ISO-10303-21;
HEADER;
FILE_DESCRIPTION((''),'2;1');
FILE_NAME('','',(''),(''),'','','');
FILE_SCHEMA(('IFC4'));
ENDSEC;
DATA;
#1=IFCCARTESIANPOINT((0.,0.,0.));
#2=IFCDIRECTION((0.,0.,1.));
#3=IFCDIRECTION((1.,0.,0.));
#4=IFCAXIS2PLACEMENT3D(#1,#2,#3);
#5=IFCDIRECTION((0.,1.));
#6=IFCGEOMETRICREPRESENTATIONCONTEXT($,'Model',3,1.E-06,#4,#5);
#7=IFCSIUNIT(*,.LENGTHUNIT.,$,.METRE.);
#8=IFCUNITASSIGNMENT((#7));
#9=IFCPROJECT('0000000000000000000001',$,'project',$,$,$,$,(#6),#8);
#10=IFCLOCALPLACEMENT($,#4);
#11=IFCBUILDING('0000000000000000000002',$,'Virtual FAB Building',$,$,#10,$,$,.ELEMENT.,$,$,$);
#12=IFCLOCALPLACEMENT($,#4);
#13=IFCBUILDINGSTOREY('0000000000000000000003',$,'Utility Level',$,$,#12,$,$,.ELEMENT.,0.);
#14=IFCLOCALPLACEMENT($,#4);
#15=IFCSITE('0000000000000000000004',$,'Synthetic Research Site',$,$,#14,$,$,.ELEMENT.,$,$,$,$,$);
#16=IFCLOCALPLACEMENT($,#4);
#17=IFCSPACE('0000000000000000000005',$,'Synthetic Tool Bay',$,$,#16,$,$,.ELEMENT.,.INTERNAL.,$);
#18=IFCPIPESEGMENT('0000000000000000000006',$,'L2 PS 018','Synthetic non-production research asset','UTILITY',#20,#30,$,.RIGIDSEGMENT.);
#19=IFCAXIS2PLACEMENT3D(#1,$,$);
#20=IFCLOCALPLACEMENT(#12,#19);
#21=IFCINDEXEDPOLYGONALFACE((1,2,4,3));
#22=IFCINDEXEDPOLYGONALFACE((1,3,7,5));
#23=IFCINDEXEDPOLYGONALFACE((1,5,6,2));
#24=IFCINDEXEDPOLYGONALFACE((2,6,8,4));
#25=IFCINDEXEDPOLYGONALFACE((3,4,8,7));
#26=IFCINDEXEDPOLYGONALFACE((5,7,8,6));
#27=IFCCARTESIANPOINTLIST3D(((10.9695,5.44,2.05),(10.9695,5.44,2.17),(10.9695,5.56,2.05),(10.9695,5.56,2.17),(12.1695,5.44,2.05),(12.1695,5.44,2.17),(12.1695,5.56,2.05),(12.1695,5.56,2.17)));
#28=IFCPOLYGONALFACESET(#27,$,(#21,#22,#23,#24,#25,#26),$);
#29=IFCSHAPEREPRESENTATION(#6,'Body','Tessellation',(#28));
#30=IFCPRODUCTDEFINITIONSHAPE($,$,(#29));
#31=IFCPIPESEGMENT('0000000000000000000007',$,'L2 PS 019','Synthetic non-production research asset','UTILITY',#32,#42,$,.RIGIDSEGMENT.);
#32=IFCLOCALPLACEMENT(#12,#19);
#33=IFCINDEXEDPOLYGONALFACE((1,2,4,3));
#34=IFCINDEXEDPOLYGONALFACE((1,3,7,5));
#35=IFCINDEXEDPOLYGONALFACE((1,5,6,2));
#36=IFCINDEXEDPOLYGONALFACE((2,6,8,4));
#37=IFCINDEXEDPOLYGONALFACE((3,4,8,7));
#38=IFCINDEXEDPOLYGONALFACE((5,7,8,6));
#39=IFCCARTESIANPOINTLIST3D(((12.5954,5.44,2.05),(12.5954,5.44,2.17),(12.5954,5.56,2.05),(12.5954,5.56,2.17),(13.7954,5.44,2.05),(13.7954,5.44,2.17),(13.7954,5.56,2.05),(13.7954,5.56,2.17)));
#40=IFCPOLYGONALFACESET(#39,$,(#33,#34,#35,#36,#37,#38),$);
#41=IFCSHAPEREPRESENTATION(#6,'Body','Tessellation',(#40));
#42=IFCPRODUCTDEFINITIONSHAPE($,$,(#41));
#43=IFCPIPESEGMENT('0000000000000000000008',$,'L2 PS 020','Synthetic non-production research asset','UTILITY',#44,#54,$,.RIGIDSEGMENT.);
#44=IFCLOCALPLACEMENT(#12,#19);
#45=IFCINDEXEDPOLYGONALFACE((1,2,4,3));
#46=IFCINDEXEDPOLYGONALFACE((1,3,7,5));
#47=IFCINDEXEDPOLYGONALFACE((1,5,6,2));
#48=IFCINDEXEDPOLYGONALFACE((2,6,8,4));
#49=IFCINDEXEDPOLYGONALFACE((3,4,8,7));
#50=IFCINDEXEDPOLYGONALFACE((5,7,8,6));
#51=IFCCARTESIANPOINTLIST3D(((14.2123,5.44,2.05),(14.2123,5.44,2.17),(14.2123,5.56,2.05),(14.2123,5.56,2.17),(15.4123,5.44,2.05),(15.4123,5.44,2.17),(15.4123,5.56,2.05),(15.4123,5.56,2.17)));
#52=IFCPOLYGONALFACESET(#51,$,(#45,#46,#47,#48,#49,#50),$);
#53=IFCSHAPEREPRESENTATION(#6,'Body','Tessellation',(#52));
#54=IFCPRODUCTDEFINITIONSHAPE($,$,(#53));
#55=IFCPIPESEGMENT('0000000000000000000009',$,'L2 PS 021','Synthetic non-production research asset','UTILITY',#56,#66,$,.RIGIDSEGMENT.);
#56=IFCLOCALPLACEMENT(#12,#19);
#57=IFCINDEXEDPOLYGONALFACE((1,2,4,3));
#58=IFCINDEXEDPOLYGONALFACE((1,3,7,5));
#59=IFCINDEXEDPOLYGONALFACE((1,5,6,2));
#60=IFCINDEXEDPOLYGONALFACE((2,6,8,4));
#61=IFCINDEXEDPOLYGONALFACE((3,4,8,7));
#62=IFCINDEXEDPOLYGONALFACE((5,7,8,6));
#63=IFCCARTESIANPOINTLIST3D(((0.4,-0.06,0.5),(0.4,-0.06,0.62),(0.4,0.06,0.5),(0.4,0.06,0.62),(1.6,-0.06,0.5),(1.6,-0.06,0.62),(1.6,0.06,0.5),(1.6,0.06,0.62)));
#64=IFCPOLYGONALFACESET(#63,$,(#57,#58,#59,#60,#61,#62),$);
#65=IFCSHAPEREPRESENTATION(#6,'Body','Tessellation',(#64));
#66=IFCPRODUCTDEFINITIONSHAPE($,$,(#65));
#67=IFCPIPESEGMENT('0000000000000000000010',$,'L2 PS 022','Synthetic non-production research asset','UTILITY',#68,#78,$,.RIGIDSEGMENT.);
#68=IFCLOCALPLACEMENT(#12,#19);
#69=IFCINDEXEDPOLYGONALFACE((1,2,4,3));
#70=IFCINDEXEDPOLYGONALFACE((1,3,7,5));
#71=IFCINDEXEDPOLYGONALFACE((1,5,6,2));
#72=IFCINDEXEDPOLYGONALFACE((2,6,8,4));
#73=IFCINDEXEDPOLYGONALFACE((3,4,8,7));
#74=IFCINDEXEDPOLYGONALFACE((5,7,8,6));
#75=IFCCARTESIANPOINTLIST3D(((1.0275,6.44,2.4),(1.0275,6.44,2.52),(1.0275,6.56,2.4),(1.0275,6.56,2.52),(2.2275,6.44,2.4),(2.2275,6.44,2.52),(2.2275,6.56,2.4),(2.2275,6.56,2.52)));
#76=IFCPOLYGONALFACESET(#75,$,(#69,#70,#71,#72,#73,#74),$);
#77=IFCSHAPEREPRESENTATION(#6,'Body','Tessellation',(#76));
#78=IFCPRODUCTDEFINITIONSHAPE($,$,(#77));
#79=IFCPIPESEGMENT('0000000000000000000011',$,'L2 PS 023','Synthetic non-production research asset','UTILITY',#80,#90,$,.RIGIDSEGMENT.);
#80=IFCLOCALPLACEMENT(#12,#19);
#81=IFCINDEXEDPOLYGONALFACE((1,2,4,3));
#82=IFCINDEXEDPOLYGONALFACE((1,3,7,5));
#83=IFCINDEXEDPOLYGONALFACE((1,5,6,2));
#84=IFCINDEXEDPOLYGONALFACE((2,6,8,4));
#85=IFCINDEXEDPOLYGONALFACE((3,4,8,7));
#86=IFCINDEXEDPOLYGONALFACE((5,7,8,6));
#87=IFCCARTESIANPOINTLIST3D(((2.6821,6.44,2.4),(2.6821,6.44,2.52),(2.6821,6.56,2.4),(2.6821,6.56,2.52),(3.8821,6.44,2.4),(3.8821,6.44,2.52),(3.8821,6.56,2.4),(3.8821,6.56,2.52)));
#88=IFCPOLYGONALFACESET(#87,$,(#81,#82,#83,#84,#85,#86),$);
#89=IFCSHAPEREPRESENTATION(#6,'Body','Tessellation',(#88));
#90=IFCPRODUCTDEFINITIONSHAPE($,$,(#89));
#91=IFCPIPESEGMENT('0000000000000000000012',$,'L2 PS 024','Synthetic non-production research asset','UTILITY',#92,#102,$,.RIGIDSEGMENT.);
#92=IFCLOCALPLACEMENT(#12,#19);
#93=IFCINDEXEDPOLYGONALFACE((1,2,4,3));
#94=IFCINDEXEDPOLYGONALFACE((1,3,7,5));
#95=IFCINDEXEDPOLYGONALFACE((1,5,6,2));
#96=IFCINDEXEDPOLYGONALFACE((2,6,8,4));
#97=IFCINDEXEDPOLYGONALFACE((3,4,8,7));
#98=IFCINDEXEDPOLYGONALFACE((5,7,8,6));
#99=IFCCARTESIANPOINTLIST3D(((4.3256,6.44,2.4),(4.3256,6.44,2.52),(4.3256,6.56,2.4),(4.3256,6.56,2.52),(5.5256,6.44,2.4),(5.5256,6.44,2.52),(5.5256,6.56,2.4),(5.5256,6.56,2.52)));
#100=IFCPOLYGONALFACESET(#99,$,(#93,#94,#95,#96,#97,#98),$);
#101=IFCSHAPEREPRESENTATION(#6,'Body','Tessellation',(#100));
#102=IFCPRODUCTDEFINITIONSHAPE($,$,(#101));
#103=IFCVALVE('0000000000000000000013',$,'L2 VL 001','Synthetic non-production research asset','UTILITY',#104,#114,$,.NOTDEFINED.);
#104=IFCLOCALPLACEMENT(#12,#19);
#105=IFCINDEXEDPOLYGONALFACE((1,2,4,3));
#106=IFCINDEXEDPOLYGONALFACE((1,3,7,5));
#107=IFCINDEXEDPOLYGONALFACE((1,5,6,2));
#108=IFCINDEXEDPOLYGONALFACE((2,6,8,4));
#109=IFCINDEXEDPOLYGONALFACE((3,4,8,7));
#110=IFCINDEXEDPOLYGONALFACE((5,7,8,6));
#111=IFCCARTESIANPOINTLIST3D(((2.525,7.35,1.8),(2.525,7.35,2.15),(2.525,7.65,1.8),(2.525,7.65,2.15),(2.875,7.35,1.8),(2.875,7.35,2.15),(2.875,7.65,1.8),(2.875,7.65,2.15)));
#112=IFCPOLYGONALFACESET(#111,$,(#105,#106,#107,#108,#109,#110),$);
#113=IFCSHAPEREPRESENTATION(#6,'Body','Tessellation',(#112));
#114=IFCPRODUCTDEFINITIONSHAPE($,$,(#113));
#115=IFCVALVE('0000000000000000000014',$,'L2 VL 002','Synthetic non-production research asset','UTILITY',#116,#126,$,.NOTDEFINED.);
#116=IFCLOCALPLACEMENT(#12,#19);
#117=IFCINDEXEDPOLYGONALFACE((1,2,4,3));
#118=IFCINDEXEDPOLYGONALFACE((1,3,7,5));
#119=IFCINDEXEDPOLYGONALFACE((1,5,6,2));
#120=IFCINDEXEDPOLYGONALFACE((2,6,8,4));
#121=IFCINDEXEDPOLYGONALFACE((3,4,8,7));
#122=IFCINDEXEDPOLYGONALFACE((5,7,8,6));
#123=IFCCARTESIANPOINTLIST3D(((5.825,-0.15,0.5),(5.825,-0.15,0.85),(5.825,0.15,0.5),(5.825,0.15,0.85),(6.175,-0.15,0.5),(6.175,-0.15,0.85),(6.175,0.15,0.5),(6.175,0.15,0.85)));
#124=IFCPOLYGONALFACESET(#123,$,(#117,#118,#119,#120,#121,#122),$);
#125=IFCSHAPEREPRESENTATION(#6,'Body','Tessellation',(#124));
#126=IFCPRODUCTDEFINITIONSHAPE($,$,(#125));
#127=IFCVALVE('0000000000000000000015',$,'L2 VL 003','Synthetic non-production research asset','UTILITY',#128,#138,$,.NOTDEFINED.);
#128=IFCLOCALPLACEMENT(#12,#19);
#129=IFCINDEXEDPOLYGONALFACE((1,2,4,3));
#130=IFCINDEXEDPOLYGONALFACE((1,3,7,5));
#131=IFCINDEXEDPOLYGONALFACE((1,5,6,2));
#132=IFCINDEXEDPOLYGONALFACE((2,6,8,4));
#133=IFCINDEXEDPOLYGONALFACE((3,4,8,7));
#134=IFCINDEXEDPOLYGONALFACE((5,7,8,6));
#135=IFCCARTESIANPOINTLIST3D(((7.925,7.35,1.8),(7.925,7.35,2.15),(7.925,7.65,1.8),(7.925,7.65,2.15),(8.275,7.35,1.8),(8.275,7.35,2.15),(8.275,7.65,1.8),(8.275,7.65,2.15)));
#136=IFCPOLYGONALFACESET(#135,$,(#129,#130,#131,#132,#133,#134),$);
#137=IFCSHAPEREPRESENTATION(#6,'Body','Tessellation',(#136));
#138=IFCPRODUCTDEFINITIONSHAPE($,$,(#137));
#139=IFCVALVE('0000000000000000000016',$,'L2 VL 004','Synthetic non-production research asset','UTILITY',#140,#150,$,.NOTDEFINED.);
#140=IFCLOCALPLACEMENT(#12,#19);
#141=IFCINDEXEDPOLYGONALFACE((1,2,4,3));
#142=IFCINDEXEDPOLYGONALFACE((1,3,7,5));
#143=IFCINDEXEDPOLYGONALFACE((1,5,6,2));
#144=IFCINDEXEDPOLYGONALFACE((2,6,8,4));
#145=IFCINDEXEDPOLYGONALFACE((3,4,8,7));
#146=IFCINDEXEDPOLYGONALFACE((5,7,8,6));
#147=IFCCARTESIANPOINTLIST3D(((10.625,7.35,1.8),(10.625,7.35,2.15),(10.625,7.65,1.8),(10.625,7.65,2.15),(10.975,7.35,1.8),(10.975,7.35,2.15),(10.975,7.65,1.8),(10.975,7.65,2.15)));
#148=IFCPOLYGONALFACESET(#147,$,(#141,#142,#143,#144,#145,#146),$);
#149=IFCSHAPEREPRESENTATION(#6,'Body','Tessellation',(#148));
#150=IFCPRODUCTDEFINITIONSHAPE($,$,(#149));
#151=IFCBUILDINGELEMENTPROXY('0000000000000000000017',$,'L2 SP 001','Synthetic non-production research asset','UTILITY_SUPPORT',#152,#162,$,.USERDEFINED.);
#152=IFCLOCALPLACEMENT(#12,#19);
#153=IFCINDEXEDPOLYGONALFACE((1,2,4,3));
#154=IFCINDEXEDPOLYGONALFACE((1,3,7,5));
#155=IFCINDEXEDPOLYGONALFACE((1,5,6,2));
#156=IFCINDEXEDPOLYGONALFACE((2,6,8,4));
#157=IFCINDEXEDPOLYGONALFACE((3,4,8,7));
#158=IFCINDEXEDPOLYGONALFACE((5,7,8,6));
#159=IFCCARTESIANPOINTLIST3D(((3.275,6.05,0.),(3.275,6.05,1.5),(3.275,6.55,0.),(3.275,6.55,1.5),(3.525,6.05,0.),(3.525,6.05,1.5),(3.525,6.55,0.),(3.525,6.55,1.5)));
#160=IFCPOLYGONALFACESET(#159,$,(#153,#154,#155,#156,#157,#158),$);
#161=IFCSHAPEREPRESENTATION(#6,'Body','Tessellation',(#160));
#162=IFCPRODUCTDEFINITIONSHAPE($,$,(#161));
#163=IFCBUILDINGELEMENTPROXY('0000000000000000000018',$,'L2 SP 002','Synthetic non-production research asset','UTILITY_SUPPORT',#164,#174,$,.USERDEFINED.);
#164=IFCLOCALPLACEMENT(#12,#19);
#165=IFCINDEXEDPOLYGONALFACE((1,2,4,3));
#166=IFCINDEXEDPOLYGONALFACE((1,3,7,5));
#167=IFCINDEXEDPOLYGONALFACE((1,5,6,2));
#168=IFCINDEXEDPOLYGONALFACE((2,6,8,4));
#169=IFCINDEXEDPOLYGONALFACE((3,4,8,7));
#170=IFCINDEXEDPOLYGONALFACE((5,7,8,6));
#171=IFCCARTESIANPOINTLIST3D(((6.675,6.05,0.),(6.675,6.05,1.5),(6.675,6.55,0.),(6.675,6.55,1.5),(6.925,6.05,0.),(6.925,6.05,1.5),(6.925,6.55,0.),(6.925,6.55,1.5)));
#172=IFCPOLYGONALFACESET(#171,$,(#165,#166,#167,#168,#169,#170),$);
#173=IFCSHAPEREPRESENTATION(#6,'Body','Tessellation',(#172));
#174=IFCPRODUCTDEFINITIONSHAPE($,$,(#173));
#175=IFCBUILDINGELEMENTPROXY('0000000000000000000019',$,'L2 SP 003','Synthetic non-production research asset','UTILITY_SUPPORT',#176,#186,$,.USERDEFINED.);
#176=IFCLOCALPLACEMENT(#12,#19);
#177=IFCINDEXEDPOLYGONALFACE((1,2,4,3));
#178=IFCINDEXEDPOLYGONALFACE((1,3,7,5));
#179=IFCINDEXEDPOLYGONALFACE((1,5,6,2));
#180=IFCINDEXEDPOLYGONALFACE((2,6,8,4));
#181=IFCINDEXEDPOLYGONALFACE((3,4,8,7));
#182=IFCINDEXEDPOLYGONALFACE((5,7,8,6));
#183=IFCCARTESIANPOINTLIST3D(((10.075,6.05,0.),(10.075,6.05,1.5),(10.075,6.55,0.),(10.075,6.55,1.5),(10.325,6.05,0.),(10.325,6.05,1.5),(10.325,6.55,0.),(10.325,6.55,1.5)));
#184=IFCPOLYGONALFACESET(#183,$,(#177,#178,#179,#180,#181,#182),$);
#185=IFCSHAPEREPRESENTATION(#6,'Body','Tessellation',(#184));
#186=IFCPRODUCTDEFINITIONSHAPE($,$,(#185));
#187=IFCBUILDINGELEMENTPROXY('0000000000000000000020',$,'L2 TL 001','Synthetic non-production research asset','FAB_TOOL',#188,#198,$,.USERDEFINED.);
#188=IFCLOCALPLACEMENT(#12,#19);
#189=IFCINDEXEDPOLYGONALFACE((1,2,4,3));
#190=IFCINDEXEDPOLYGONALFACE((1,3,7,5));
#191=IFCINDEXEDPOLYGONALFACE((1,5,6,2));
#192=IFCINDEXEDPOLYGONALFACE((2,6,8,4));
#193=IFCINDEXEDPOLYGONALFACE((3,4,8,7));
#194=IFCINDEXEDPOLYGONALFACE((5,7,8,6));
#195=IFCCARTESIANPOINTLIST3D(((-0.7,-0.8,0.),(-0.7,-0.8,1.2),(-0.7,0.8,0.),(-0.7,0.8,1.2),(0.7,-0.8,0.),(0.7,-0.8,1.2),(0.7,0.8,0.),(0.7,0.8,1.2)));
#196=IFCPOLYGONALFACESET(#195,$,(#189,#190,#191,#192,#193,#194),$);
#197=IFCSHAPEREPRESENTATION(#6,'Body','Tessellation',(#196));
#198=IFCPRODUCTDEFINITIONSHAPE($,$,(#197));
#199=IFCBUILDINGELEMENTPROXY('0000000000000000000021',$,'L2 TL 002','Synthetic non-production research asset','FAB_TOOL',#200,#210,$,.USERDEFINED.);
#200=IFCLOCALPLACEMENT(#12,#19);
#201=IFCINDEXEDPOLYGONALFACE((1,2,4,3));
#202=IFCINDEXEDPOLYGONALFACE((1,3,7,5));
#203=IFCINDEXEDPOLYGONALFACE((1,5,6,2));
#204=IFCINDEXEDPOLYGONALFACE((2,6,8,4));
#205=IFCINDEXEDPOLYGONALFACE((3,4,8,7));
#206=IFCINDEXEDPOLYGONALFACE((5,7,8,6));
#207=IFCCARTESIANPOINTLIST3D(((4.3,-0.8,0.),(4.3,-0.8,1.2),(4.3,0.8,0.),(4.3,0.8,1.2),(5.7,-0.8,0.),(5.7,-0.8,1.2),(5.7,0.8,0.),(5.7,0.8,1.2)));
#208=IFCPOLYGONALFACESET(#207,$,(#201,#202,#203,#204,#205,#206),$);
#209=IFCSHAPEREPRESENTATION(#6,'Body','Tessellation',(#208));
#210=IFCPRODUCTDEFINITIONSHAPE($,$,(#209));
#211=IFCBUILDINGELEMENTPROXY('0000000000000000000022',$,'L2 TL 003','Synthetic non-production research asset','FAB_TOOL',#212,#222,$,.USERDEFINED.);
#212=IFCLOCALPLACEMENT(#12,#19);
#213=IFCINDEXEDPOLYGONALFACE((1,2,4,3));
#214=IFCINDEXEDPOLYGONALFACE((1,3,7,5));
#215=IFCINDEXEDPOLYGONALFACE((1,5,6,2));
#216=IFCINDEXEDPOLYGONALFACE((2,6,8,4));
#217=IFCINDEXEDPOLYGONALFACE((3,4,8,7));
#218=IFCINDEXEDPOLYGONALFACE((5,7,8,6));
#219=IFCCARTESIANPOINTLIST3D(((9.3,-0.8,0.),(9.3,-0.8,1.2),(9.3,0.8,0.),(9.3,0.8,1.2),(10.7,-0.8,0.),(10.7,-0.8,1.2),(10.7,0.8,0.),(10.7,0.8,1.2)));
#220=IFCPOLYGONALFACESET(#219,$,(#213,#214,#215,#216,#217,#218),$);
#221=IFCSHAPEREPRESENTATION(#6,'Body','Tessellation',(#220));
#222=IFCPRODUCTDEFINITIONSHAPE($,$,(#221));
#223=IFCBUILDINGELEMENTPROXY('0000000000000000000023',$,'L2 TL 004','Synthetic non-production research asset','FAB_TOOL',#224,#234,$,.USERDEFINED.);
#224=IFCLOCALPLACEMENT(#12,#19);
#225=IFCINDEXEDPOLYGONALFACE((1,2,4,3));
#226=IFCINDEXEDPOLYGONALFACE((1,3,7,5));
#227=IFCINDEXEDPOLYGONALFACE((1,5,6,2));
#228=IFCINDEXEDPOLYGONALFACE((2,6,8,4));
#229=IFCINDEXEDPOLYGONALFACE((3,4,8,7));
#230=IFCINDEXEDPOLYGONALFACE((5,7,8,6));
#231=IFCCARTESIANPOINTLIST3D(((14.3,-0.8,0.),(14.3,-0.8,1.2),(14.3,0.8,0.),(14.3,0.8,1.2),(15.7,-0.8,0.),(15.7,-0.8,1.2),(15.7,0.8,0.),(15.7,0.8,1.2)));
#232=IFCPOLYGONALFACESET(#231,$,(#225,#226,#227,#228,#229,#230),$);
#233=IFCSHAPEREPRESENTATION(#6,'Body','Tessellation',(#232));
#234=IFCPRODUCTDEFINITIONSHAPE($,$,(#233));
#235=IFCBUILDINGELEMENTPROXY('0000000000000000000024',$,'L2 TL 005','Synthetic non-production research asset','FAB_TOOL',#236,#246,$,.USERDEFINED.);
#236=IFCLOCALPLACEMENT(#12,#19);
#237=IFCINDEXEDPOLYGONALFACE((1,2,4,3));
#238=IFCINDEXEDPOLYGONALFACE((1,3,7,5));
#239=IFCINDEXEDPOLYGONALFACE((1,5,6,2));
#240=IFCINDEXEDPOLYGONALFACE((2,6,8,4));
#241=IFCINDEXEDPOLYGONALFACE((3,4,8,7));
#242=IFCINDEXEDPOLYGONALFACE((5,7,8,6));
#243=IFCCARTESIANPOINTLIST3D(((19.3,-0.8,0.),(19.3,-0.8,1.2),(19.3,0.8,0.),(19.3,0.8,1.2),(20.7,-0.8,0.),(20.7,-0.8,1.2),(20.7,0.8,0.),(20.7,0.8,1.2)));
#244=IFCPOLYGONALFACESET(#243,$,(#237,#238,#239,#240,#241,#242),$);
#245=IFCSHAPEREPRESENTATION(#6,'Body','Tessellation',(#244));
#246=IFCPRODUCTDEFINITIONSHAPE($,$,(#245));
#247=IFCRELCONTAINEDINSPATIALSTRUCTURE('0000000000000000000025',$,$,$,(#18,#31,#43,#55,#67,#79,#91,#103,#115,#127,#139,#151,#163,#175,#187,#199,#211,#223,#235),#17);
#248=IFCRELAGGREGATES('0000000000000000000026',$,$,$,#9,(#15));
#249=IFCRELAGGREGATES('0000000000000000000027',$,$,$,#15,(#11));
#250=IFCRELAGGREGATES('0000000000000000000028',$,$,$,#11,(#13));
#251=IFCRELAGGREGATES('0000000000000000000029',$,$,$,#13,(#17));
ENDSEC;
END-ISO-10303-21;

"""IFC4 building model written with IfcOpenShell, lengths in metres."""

from ifc_helpers import new_model, si_unit, direction, frame, origin_with_axes, origin_2d_with_axis, place, context, project, spatial, rectangle, extrude, element, save


model = new_model("IFC4")

# Units and contexts
model_context = context("Model", 3, precision=1e-06, world=origin_with_axes(), true_north=direction((0.0, 1.0)))
ifc_project = project(units=[si_unit("LENGTHUNIT", "METRE")], contexts=[model_context])

# Site, building, storey, space
site_placement = place(None, origin_with_axes())
site = spatial("IfcSite", under=ifc_project, at=site_placement, Name="Synthetic Research Site", CompositionType="ELEMENT")
building_placement = place(None, origin_with_axes())
building = spatial("IfcBuilding", under=site, at=building_placement, Name="Virtual FAB Building", CompositionType="ELEMENT")
storey_placement = place(None, origin_with_axes())
storey = spatial("IfcBuildingStorey", under=building, at=storey_placement, Name="Utility Level", CompositionType="ELEMENT", Elevation=0.0)
space_placement = place(None, origin_with_axes())
space = spatial("IfcSpace", under=storey, at=space_placement, Name="Synthetic Tool Bay", CompositionType="ELEMENT", PredefinedType="INTERNAL")

# Pipe segments
for number, where, z_axis, x_axis, name in (
    (1, (11.5695, 5.5, 2.05), (0.0, 0.0, 1.0), (1.0, 0.0, 0.0), "L2 PS 018"),
    (2, (13.1954, 5.5, 2.05), (0.0, 0.0, 1.0), (1.0, 0.0, 0.0), "L2 PS 019"),
    (3, (14.8123, 5.5, 2.05), (0.0, 0.0, 1.0), (1.0, 0.0, 0.0), "L2 PS 020"),
    (4, (1.0, 0.0, 0.5), (0.0, 0.0, 1.0), (1.0, 0.0, 0.0), "L2 PS 021"),
    (5, (1.6275, 6.5, 2.4), (0.0, 0.0, 1.0), (1.0, 0.0, 0.0), "L2 PS 022"),
    (6, (3.2821, 6.5, 2.4), (0.0, 0.0, 1.0), (1.0, 0.0, 0.0), "L2 PS 023"),
    (7, (4.9256, 6.5, 2.4), (0.0, 0.0, 1.0), (1.0, 0.0, 0.0), "L2 PS 024"),
):
    element("IfcPipeSegment", number, at=place(None, frame(where, z_axis=z_axis, x_axis=x_axis)), inside=space, Name=name, Description="Synthetic non-production research asset", ObjectType="UTILITY", PredefinedType="RIGIDSEGMENT", context=model_context, shape_type="SweptSolid", body=[
        extrude(rectangle(XDim=1.2, YDim=0.12, at=origin_2d_with_axis()), origin_with_axes(), (0.0, 0.0, 1.0), 0.12),
    ])

# Valves
for number, where, z_axis, x_axis, name in (
    (8, (2.7, 7.5, 1.8), (0.0, 0.0, 1.0), (1.0, 0.0, 0.0), "L2 VL 001"),
    (9, (6.0, 0.0, 0.5), (0.0, 0.0, 1.0), (1.0, 0.0, 0.0), "L2 VL 002"),
    (10, (8.1, 7.5, 1.8), (0.0, 0.0, 1.0), (1.0, 0.0, 0.0), "L2 VL 003"),
    (11, (10.8, 7.5, 1.8), (0.0, 0.0, 1.0), (1.0, 0.0, 0.0), "L2 VL 004"),
):
    element("IfcValve", number, at=place(None, frame(where, z_axis=z_axis, x_axis=x_axis)), inside=space, Name=name, Description="Synthetic non-production research asset", ObjectType="UTILITY", PredefinedType="NOTDEFINED", context=model_context, shape_type="SweptSolid", body=[
        extrude(rectangle(XDim=0.35, YDim=0.3, at=origin_2d_with_axis()), origin_with_axes(), (0.0, 0.0, 1.0), 0.35),
    ])

# Building element proxies
for number, where, z_axis, x_axis, name in (
    (12, (3.4, 6.3, 0.0), (0.0, 0.0, 1.0), (1.0, 0.0, 0.0), "L2 SP 001"),
    (13, (6.8, 6.3, 0.0), (0.0, 0.0, 1.0), (1.0, 0.0, 0.0), "L2 SP 002"),
    (14, (10.2, 6.3, 0.0), (0.0, 0.0, 1.0), (1.0, 0.0, 0.0), "L2 SP 003"),
):
    element("IfcBuildingElementProxy", number, at=place(None, frame(where, z_axis=z_axis, x_axis=x_axis)), inside=space, Name=name, Description="Synthetic non-production research asset", ObjectType="UTILITY_SUPPORT", PredefinedType="USERDEFINED", context=model_context, shape_type="SweptSolid", body=[
        extrude(rectangle(XDim=0.25, YDim=0.5, at=origin_2d_with_axis()), origin_with_axes(), (0.0, 0.0, 1.0), 1.5),
    ])
for number, where, z_axis, x_axis, name in (
    (15, (0.0, 0.0, 0.0), (0.0, 0.0, 1.0), (1.0, 0.0, 0.0), "L2 TL 001"),
    (16, (5.0, 0.0, 0.0), (0.0, 0.0, 1.0), (1.0, 0.0, 0.0), "L2 TL 002"),
    (17, (10.0, 0.0, 0.0), (0.0, 0.0, 1.0), (1.0, 0.0, 0.0), "L2 TL 003"),
    (18, (15.0, 0.0, 0.0), (0.0, 0.0, 1.0), (1.0, 0.0, 0.0), "L2 TL 004"),
    (19, (20.0, 0.0, 0.0), (0.0, 0.0, 1.0), (1.0, 0.0, 0.0), "L2 TL 005"),
):
    element("IfcBuildingElementProxy", number, at=place(None, frame(where, z_axis=z_axis, x_axis=x_axis)), inside=space, Name=name, Description="Synthetic non-production research asset", ObjectType="FAB_TOOL", PredefinedType="USERDEFINED", context=model_context, shape_type="SweptSolid", body=[
        extrude(rectangle(XDim=1.4, YDim=1.6, at=origin_2d_with_axis()), origin_with_axes(), (0.0, 0.0, 1.0), 1.2),
    ])

save(model, "model.ifc")
